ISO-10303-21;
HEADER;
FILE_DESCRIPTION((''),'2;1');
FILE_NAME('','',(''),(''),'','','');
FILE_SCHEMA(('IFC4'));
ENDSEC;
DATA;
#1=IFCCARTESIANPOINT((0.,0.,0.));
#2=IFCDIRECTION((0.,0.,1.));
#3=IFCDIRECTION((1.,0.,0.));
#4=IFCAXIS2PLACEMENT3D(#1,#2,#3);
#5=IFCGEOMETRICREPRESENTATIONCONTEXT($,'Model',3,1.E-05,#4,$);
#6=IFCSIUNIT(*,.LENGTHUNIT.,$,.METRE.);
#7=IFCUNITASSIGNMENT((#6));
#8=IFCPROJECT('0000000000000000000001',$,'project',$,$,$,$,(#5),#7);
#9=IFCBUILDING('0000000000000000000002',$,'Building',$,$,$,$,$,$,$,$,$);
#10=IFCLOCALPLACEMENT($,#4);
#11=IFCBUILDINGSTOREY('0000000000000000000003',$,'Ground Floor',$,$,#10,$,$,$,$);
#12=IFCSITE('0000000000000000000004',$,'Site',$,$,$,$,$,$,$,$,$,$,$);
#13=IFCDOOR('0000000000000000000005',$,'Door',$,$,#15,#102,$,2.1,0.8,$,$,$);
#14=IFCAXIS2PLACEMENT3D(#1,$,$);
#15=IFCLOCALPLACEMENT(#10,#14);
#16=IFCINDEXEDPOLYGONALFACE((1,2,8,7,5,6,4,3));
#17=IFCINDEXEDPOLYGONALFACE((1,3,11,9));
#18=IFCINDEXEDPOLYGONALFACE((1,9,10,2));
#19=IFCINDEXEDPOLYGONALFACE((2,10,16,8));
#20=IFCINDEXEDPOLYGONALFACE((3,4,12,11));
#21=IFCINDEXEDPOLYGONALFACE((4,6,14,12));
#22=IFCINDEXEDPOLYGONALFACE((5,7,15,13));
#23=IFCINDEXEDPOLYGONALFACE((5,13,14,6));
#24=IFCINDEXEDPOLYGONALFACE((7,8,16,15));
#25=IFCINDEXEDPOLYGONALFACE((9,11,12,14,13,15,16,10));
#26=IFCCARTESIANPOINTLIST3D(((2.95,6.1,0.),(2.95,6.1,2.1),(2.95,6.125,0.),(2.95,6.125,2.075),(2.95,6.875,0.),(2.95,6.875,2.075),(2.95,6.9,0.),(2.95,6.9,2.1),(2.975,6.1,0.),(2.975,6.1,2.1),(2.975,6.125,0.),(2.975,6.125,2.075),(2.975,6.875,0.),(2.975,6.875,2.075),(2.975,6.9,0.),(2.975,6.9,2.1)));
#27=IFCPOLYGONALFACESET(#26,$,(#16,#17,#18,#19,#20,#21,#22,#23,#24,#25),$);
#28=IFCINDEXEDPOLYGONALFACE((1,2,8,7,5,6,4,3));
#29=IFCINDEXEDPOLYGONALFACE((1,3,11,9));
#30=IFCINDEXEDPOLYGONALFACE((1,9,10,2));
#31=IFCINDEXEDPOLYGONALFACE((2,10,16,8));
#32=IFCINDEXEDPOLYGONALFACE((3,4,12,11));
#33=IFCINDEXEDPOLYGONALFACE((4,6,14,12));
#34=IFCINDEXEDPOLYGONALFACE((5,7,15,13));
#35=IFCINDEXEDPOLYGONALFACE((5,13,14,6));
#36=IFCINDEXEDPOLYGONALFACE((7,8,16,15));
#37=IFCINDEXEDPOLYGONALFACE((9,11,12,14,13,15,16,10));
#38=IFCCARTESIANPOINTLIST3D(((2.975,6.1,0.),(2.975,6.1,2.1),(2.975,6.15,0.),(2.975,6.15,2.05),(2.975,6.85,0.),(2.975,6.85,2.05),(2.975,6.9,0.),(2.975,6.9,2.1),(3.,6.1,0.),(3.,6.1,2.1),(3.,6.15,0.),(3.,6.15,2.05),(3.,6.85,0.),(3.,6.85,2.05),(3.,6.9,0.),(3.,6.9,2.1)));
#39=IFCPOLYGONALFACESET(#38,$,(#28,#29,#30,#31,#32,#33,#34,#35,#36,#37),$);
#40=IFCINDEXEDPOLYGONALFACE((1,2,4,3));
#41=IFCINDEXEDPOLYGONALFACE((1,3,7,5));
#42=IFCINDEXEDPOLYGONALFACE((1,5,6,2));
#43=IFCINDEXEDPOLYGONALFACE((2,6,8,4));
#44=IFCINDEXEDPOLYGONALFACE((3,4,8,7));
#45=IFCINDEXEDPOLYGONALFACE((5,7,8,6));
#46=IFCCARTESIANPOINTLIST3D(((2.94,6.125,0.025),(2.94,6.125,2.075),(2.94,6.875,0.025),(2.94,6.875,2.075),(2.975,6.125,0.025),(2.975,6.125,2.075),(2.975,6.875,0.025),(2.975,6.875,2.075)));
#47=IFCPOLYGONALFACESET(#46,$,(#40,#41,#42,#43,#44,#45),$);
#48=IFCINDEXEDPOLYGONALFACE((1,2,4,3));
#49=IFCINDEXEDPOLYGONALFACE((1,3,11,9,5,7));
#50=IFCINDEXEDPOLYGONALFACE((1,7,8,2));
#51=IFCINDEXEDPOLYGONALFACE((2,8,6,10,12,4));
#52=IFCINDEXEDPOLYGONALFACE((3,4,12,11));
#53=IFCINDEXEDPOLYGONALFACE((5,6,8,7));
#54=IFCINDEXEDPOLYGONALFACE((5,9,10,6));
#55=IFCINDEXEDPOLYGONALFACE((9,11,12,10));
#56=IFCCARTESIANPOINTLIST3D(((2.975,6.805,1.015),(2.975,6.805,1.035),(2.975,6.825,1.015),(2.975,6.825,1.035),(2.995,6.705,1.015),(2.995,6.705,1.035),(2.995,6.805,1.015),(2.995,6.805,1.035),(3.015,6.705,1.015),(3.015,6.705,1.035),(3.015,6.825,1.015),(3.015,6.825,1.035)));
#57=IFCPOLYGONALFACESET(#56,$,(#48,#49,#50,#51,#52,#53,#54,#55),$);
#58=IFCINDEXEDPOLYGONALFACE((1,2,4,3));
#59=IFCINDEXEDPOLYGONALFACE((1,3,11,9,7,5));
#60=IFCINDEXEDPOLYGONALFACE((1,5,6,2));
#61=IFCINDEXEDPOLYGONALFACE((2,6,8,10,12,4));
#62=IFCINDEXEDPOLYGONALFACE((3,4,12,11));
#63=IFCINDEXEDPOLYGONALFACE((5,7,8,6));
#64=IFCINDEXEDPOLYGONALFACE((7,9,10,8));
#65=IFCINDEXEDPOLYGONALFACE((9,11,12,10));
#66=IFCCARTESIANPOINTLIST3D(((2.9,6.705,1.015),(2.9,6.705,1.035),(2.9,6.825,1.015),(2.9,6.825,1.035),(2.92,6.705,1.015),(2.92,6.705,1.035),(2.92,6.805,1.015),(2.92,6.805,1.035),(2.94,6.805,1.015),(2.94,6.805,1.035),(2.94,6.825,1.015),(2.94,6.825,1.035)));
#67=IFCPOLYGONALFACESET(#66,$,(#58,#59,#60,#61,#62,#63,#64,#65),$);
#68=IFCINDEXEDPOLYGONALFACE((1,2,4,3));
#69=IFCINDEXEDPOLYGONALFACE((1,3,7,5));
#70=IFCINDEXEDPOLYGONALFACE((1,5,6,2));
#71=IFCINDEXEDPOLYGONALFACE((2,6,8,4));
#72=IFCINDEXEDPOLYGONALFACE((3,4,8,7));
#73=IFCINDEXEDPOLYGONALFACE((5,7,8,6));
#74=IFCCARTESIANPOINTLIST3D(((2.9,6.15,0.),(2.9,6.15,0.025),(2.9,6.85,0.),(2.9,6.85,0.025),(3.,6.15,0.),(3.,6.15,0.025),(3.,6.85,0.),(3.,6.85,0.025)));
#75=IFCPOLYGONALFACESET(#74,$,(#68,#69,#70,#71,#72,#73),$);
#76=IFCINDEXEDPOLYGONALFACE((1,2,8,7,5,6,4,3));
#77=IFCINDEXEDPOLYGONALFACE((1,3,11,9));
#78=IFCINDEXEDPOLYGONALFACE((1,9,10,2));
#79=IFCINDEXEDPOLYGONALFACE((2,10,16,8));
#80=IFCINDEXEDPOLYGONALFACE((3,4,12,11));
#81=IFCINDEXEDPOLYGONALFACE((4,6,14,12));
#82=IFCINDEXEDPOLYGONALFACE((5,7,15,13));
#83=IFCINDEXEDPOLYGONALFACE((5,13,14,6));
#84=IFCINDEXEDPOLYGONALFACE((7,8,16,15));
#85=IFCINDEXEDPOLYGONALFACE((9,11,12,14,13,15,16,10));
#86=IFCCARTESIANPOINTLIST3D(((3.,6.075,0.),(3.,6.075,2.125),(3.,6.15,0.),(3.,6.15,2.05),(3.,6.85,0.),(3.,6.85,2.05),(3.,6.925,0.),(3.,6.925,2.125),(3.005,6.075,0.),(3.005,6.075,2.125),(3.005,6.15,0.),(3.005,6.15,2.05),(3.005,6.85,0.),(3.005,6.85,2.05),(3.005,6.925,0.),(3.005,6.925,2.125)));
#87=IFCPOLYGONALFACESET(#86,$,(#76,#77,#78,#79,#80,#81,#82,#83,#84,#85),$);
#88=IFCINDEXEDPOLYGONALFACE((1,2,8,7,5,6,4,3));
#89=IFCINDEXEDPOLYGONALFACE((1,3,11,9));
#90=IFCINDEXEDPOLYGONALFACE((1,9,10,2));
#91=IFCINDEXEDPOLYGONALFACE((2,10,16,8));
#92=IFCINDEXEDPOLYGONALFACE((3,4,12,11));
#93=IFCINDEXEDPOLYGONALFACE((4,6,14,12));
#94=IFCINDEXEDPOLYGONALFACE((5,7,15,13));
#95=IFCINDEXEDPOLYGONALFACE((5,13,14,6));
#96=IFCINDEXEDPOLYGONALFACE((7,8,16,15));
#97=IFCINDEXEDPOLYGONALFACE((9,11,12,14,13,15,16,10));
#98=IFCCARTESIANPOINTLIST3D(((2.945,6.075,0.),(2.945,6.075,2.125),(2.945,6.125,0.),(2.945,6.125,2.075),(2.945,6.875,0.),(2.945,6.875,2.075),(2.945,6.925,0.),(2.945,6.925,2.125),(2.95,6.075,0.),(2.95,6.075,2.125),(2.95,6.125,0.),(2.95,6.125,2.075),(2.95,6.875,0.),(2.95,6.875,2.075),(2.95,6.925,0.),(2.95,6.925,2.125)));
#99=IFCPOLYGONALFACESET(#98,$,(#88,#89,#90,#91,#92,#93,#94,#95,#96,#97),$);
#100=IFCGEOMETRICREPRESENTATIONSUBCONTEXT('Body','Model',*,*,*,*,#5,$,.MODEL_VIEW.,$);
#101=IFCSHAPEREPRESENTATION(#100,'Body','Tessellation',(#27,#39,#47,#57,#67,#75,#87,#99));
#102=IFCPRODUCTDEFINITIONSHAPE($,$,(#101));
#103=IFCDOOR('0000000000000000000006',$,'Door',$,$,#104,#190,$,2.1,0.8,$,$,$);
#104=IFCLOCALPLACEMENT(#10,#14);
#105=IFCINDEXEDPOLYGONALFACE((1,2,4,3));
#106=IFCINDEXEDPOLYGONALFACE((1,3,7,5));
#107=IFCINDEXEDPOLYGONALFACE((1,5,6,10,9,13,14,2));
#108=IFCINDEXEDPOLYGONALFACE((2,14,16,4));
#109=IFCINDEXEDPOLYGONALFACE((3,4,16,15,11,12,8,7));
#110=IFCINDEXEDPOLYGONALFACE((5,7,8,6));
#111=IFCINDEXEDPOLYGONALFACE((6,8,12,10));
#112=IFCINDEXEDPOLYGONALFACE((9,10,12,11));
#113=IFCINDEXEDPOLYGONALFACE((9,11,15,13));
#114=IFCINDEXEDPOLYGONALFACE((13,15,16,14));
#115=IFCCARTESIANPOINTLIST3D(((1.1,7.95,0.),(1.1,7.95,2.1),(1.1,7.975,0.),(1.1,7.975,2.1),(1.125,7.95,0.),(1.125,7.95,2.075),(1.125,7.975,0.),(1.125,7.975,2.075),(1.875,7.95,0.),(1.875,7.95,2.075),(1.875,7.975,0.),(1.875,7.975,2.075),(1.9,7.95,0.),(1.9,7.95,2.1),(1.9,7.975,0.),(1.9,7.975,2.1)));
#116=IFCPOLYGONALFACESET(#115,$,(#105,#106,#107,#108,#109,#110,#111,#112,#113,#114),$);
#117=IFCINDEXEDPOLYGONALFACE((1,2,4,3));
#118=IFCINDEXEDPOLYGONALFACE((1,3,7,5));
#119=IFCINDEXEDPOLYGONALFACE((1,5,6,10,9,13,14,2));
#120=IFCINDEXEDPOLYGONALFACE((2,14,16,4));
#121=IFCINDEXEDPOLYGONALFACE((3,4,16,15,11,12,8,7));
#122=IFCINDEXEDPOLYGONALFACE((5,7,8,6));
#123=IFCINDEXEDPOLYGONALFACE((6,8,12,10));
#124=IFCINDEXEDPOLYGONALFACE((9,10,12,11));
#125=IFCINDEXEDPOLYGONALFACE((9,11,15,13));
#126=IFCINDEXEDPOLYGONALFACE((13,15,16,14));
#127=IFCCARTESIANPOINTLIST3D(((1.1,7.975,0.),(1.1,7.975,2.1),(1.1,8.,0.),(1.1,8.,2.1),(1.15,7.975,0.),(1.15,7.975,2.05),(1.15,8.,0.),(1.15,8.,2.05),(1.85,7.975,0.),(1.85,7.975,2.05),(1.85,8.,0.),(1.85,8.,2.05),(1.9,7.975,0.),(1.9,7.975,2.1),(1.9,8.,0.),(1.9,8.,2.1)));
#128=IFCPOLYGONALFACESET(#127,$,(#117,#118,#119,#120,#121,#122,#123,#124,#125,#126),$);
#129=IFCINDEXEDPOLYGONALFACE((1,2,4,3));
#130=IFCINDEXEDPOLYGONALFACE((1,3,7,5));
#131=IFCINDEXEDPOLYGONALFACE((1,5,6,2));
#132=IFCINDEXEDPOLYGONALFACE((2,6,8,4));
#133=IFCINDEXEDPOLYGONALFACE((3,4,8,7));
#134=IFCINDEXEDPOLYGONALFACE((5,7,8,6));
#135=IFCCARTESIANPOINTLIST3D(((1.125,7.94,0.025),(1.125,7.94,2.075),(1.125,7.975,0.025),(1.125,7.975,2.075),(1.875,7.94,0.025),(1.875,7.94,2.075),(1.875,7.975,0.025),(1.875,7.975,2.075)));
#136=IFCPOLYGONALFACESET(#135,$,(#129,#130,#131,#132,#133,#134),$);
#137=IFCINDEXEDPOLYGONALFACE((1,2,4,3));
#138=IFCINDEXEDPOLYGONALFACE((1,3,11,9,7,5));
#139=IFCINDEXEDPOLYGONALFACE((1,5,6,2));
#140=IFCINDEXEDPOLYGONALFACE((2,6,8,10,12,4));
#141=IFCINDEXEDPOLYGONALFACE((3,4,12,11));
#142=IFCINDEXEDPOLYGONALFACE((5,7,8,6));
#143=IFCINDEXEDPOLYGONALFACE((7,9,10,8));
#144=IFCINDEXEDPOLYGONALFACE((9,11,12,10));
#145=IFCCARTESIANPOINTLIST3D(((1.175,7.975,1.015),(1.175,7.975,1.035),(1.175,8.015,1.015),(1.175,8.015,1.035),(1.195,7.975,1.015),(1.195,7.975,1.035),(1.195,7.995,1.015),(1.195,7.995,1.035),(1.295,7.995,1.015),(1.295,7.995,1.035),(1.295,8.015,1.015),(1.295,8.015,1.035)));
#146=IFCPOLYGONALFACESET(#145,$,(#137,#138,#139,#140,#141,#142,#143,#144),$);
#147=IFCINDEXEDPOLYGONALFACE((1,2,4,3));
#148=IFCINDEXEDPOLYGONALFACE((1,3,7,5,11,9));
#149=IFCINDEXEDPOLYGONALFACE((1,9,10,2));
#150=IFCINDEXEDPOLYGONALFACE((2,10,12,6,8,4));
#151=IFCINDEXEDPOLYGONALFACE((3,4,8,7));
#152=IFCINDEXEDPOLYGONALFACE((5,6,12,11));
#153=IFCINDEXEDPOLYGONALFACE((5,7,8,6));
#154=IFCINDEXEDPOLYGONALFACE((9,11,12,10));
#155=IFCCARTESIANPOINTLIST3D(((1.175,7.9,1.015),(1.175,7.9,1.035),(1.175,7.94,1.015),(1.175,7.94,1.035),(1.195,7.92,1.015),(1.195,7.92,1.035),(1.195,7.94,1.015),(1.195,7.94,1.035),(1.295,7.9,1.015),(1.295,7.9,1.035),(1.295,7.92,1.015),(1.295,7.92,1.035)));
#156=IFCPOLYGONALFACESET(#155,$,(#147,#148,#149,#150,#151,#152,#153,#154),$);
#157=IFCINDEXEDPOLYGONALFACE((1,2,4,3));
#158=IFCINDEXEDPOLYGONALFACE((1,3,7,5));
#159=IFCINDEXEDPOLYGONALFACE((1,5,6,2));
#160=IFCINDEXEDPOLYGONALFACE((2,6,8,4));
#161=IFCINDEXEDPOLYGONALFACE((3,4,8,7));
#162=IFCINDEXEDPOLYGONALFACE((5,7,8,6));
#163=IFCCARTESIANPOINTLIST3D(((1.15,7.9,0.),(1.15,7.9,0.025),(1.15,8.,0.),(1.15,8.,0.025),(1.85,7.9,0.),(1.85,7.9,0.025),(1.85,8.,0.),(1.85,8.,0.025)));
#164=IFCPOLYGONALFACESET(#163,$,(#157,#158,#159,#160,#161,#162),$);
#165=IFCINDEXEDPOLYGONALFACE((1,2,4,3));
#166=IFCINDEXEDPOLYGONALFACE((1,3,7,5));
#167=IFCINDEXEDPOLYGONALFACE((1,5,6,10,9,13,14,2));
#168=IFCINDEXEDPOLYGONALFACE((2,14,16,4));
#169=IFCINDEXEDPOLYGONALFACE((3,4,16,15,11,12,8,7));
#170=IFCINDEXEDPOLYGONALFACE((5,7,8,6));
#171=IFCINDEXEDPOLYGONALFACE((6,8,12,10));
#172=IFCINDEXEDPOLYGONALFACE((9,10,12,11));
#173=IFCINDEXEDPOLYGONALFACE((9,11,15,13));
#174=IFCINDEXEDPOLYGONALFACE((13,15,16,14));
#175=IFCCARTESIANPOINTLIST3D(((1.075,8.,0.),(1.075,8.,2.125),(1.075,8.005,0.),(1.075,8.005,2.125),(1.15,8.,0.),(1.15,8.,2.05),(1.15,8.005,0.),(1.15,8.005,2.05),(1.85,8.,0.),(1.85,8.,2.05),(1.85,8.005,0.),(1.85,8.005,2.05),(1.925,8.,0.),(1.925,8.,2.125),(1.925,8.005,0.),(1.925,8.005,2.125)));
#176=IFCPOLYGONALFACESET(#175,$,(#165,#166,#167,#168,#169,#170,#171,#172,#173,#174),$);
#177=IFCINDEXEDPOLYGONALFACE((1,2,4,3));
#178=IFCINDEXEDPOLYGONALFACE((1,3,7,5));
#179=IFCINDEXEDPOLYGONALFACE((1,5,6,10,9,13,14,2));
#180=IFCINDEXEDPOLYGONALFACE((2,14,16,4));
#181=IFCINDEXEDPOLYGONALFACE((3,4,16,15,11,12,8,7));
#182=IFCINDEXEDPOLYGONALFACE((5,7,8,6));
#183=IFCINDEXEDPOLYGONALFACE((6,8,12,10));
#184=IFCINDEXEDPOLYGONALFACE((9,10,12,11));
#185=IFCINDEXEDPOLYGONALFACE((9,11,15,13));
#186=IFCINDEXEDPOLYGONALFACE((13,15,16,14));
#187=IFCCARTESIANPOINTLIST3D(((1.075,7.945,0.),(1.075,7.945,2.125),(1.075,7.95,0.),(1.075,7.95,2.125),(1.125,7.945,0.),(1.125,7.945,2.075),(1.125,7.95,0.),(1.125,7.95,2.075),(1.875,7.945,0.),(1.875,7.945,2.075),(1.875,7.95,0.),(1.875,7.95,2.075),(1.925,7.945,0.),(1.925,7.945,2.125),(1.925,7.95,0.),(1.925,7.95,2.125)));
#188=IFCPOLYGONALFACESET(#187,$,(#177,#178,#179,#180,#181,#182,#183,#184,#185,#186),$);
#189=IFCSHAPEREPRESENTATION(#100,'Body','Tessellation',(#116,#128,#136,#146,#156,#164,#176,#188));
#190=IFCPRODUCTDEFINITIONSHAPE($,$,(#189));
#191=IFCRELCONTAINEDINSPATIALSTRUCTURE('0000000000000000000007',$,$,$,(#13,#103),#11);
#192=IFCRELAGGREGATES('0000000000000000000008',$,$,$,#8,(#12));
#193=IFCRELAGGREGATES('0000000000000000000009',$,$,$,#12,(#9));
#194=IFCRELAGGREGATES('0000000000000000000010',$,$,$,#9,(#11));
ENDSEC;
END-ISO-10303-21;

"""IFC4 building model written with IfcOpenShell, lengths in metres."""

from ifc_helpers import new_model, si_unit, frame, origin_with_axes, place, context, subcontext, project, spatial, line, indexed_curve, outline, extrude, element, save


model = new_model("IFC4")

# Units and contexts
model_context = context("Model", 3, precision=1e-05, world=origin_with_axes())
body_context = subcontext(model_context, "Body", "Model", "MODEL_VIEW")
ifc_project = project(units=[si_unit("LENGTHUNIT", "METRE")], contexts=[model_context])

# Site, building, storey
site = spatial("IfcSite", under=ifc_project, Name="Site")
building = spatial("IfcBuilding", under=site, Name="Building")
storey_placement = place(None, origin_with_axes())
storey = spatial("IfcBuildingStorey", under=building, at=storey_placement, Name="Ground Floor")

# Doors
door_1_placement = place(storey_placement, frame((3.0, 6.1, 0.0), z_axis=(0.0, 0.0, 1.0), x_axis=(0.0, 1.0, 0.0)))
element("IfcDoor", 1, at=door_1_placement, inside=storey, Name="Door", OverallHeight=2.1, OverallWidth=0.8, context=body_context, shape_type="SweptSolid", body=[
    extrude(outline(indexed_curve([(0.0, 0.0), (0.0, 2.1), (0.8, 2.1), (0.8, 0.0), (0.775, 0.0), (0.775, 2.075), (0.025, 2.075), (0.025, 0.0)], segments=[line(1, 2, 3, 4, 5, 6, 7, 8, 1)])), frame((0.0, 0.025, 0.0), z_axis=(0.0, -1.0, 0.0), x_axis=(1.0, 0.0, 0.0)), (0.0, 0.0, -1.0), 0.025),
    extrude(outline(indexed_curve([(0.0, 0.0), (0.0, 2.1), (0.8, 2.1), (0.8, 0.0), (0.75, 0.0), (0.75, 2.05), (0.05, 2.05), (0.05, 0.0)], segments=[line(1, 2, 3, 4, 5, 6, 7, 8, 1)])), frame((0.0, 0.0, 0.0), z_axis=(0.0, -1.0, 0.0), x_axis=(1.0, 0.0, 0.0)), (0.0, 0.0, -1.0), 0.025),
    extrude(outline(indexed_curve([(0.0, 0.0), (0.75, 0.0), (0.75, 0.035), (0.0, 0.035)], segments=[line(1, 2, 3, 4, 1)])), frame((0.025, 0.025, 0.025), z_axis=(0.0, 0.0, 1.0), x_axis=(1.0, 0.0, 0.0)), (0.0, 0.0, 1.0), 2.05),
    extrude(outline(indexed_curve([(0.0, 0.0), (0.0, -0.04), (-0.12, -0.04), (-0.12, -0.02), (-0.02, -0.02), (-0.02, 0.0)], segments=[line(1, 2, 3, 4, 5, 6, 1)])), frame((0.725, 0.025, 1.015), z_axis=(0.0, 0.0, 1.0), x_axis=(1.0, 0.0, 0.0)), (0.0, 0.0, 1.0), 0.02),
    extrude(outline(indexed_curve([(0.0, 0.0), (0.0, 0.04), (-0.12, 0.04), (-0.12, 0.02), (-0.02, 0.02), (-0.02, 0.0)], segments=[line(1, 2, 3, 4, 5, 6, 1)])), frame((0.725, 0.06, 1.015), z_axis=(0.0, 0.0, 1.0), x_axis=(1.0, 0.0, 0.0)), (0.0, 0.0, 1.0), 0.02),
    extrude(outline(indexed_curve([(0.0, 0.0), (0.7, 0.0), (0.7, 0.1), (0.0, 0.1)], segments=[line(1, 2, 3, 4, 1)])), frame((0.05, 0.0, 0.0), z_axis=(0.0, 0.0, 1.0), x_axis=(1.0, 0.0, 0.0)), (0.0, 0.0, 1.0), 0.025),
    extrude(outline(indexed_curve([(0.0, 0.0), (0.0, 2.125), (0.85, 2.125), (0.85, 0.0), (0.775, 0.0), (0.775, 2.05), (0.075, 2.05), (0.075, 0.0)], segments=[line(1, 2, 3, 4, 5, 6, 7, 8, 1)])), frame((-0.025, -0.005, 0.0), z_axis=(0.0, -1.0, 0.0), x_axis=(1.0, 0.0, 0.0)), (0.0, 0.0, -1.0), 0.005),
    extrude(outline(indexed_curve([(0.0, 0.0), (0.0, 2.125), (0.85, 2.125), (0.85, 0.0), (0.8, 0.0), (0.8, 2.075), (0.05, 2.075), (0.05, 0.0)], segments=[line(1, 2, 3, 4, 5, 6, 7, 8, 1)])), frame((-0.025, 0.05, 0.0), z_axis=(0.0, -1.0, 0.0), x_axis=(1.0, 0.0, 0.0)), (0.0, 0.0, -1.0), 0.005),
])
door_2_placement = place(storey_placement, frame((1.9, 8.0, 0.0), z_axis=(0.0, 0.0, 1.0), x_axis=(-1.0, 0.0, 0.0)))
element("IfcDoor", 2, at=door_2_placement, inside=storey, Name="Door", OverallHeight=2.1, OverallWidth=0.8, context=body_context, shape_type="SweptSolid", body=[
    extrude(outline(indexed_curve([(0.0, 0.0), (0.0, 2.1), (0.8, 2.1), (0.8, 0.0), (0.775, 0.0), (0.775, 2.075), (0.025, 2.075), (0.025, 0.0)], segments=[line(1, 2, 3, 4, 5, 6, 7, 8, 1)])), frame((0.0, 0.025, 0.0), z_axis=(0.0, -1.0, 0.0), x_axis=(1.0, 0.0, 0.0)), (0.0, 0.0, -1.0), 0.025),
    extrude(outline(indexed_curve([(0.0, 0.0), (0.0, 2.1), (0.8, 2.1), (0.8, 0.0), (0.75, 0.0), (0.75, 2.05), (0.05, 2.05), (0.05, 0.0)], segments=[line(1, 2, 3, 4, 5, 6, 7, 8, 1)])), frame((0.0, 0.0, 0.0), z_axis=(0.0, -1.0, 0.0), x_axis=(1.0, 0.0, 0.0)), (0.0, 0.0, -1.0), 0.025),
    extrude(outline(indexed_curve([(0.0, 0.0), (0.75, 0.0), (0.75, 0.035), (0.0, 0.035)], segments=[line(1, 2, 3, 4, 1)])), frame((0.025, 0.025, 0.025), z_axis=(0.0, 0.0, 1.0), x_axis=(1.0, 0.0, 0.0)), (0.0, 0.0, 1.0), 2.05),
    extrude(outline(indexed_curve([(0.0, 0.0), (0.0, -0.04), (-0.12, -0.04), (-0.12, -0.02), (-0.02, -0.02), (-0.02, 0.0)], segments=[line(1, 2, 3, 4, 5, 6, 1)])), frame((0.725, 0.025, 1.015), z_axis=(0.0, 0.0, 1.0), x_axis=(1.0, 0.0, 0.0)), (0.0, 0.0, 1.0), 0.02),
    extrude(outline(indexed_curve([(0.0, 0.0), (0.0, 0.04), (-0.12, 0.04), (-0.12, 0.02), (-0.02, 0.02), (-0.02, 0.0)], segments=[line(1, 2, 3, 4, 5, 6, 1)])), frame((0.725, 0.06, 1.015), z_axis=(0.0, 0.0, 1.0), x_axis=(1.0, 0.0, 0.0)), (0.0, 0.0, 1.0), 0.02),
    extrude(outline(indexed_curve([(0.0, 0.0), (0.7, 0.0), (0.7, 0.1), (0.0, 0.1)], segments=[line(1, 2, 3, 4, 1)])), frame((0.05, 0.0, 0.0), z_axis=(0.0, 0.0, 1.0), x_axis=(1.0, 0.0, 0.0)), (0.0, 0.0, 1.0), 0.025),
    extrude(outline(indexed_curve([(0.0, 0.0), (0.0, 2.125), (0.85, 2.125), (0.85, 0.0), (0.775, 0.0), (0.775, 2.05), (0.075, 2.05), (0.075, 0.0)], segments=[line(1, 2, 3, 4, 5, 6, 7, 8, 1)])), frame((-0.025, -0.005, 0.0), z_axis=(0.0, -1.0, 0.0), x_axis=(1.0, 0.0, 0.0)), (0.0, 0.0, -1.0), 0.005),
    extrude(outline(indexed_curve([(0.0, 0.0), (0.0, 2.125), (0.85, 2.125), (0.85, 0.0), (0.8, 0.0), (0.8, 2.075), (0.05, 2.075), (0.05, 0.0)], segments=[line(1, 2, 3, 4, 5, 6, 7, 8, 1)])), frame((-0.025, 0.05, 0.0), z_axis=(0.0, -1.0, 0.0), x_axis=(1.0, 0.0, 0.0)), (0.0, 0.0, -1.0), 0.005),
])

save(model, "model.ifc")
